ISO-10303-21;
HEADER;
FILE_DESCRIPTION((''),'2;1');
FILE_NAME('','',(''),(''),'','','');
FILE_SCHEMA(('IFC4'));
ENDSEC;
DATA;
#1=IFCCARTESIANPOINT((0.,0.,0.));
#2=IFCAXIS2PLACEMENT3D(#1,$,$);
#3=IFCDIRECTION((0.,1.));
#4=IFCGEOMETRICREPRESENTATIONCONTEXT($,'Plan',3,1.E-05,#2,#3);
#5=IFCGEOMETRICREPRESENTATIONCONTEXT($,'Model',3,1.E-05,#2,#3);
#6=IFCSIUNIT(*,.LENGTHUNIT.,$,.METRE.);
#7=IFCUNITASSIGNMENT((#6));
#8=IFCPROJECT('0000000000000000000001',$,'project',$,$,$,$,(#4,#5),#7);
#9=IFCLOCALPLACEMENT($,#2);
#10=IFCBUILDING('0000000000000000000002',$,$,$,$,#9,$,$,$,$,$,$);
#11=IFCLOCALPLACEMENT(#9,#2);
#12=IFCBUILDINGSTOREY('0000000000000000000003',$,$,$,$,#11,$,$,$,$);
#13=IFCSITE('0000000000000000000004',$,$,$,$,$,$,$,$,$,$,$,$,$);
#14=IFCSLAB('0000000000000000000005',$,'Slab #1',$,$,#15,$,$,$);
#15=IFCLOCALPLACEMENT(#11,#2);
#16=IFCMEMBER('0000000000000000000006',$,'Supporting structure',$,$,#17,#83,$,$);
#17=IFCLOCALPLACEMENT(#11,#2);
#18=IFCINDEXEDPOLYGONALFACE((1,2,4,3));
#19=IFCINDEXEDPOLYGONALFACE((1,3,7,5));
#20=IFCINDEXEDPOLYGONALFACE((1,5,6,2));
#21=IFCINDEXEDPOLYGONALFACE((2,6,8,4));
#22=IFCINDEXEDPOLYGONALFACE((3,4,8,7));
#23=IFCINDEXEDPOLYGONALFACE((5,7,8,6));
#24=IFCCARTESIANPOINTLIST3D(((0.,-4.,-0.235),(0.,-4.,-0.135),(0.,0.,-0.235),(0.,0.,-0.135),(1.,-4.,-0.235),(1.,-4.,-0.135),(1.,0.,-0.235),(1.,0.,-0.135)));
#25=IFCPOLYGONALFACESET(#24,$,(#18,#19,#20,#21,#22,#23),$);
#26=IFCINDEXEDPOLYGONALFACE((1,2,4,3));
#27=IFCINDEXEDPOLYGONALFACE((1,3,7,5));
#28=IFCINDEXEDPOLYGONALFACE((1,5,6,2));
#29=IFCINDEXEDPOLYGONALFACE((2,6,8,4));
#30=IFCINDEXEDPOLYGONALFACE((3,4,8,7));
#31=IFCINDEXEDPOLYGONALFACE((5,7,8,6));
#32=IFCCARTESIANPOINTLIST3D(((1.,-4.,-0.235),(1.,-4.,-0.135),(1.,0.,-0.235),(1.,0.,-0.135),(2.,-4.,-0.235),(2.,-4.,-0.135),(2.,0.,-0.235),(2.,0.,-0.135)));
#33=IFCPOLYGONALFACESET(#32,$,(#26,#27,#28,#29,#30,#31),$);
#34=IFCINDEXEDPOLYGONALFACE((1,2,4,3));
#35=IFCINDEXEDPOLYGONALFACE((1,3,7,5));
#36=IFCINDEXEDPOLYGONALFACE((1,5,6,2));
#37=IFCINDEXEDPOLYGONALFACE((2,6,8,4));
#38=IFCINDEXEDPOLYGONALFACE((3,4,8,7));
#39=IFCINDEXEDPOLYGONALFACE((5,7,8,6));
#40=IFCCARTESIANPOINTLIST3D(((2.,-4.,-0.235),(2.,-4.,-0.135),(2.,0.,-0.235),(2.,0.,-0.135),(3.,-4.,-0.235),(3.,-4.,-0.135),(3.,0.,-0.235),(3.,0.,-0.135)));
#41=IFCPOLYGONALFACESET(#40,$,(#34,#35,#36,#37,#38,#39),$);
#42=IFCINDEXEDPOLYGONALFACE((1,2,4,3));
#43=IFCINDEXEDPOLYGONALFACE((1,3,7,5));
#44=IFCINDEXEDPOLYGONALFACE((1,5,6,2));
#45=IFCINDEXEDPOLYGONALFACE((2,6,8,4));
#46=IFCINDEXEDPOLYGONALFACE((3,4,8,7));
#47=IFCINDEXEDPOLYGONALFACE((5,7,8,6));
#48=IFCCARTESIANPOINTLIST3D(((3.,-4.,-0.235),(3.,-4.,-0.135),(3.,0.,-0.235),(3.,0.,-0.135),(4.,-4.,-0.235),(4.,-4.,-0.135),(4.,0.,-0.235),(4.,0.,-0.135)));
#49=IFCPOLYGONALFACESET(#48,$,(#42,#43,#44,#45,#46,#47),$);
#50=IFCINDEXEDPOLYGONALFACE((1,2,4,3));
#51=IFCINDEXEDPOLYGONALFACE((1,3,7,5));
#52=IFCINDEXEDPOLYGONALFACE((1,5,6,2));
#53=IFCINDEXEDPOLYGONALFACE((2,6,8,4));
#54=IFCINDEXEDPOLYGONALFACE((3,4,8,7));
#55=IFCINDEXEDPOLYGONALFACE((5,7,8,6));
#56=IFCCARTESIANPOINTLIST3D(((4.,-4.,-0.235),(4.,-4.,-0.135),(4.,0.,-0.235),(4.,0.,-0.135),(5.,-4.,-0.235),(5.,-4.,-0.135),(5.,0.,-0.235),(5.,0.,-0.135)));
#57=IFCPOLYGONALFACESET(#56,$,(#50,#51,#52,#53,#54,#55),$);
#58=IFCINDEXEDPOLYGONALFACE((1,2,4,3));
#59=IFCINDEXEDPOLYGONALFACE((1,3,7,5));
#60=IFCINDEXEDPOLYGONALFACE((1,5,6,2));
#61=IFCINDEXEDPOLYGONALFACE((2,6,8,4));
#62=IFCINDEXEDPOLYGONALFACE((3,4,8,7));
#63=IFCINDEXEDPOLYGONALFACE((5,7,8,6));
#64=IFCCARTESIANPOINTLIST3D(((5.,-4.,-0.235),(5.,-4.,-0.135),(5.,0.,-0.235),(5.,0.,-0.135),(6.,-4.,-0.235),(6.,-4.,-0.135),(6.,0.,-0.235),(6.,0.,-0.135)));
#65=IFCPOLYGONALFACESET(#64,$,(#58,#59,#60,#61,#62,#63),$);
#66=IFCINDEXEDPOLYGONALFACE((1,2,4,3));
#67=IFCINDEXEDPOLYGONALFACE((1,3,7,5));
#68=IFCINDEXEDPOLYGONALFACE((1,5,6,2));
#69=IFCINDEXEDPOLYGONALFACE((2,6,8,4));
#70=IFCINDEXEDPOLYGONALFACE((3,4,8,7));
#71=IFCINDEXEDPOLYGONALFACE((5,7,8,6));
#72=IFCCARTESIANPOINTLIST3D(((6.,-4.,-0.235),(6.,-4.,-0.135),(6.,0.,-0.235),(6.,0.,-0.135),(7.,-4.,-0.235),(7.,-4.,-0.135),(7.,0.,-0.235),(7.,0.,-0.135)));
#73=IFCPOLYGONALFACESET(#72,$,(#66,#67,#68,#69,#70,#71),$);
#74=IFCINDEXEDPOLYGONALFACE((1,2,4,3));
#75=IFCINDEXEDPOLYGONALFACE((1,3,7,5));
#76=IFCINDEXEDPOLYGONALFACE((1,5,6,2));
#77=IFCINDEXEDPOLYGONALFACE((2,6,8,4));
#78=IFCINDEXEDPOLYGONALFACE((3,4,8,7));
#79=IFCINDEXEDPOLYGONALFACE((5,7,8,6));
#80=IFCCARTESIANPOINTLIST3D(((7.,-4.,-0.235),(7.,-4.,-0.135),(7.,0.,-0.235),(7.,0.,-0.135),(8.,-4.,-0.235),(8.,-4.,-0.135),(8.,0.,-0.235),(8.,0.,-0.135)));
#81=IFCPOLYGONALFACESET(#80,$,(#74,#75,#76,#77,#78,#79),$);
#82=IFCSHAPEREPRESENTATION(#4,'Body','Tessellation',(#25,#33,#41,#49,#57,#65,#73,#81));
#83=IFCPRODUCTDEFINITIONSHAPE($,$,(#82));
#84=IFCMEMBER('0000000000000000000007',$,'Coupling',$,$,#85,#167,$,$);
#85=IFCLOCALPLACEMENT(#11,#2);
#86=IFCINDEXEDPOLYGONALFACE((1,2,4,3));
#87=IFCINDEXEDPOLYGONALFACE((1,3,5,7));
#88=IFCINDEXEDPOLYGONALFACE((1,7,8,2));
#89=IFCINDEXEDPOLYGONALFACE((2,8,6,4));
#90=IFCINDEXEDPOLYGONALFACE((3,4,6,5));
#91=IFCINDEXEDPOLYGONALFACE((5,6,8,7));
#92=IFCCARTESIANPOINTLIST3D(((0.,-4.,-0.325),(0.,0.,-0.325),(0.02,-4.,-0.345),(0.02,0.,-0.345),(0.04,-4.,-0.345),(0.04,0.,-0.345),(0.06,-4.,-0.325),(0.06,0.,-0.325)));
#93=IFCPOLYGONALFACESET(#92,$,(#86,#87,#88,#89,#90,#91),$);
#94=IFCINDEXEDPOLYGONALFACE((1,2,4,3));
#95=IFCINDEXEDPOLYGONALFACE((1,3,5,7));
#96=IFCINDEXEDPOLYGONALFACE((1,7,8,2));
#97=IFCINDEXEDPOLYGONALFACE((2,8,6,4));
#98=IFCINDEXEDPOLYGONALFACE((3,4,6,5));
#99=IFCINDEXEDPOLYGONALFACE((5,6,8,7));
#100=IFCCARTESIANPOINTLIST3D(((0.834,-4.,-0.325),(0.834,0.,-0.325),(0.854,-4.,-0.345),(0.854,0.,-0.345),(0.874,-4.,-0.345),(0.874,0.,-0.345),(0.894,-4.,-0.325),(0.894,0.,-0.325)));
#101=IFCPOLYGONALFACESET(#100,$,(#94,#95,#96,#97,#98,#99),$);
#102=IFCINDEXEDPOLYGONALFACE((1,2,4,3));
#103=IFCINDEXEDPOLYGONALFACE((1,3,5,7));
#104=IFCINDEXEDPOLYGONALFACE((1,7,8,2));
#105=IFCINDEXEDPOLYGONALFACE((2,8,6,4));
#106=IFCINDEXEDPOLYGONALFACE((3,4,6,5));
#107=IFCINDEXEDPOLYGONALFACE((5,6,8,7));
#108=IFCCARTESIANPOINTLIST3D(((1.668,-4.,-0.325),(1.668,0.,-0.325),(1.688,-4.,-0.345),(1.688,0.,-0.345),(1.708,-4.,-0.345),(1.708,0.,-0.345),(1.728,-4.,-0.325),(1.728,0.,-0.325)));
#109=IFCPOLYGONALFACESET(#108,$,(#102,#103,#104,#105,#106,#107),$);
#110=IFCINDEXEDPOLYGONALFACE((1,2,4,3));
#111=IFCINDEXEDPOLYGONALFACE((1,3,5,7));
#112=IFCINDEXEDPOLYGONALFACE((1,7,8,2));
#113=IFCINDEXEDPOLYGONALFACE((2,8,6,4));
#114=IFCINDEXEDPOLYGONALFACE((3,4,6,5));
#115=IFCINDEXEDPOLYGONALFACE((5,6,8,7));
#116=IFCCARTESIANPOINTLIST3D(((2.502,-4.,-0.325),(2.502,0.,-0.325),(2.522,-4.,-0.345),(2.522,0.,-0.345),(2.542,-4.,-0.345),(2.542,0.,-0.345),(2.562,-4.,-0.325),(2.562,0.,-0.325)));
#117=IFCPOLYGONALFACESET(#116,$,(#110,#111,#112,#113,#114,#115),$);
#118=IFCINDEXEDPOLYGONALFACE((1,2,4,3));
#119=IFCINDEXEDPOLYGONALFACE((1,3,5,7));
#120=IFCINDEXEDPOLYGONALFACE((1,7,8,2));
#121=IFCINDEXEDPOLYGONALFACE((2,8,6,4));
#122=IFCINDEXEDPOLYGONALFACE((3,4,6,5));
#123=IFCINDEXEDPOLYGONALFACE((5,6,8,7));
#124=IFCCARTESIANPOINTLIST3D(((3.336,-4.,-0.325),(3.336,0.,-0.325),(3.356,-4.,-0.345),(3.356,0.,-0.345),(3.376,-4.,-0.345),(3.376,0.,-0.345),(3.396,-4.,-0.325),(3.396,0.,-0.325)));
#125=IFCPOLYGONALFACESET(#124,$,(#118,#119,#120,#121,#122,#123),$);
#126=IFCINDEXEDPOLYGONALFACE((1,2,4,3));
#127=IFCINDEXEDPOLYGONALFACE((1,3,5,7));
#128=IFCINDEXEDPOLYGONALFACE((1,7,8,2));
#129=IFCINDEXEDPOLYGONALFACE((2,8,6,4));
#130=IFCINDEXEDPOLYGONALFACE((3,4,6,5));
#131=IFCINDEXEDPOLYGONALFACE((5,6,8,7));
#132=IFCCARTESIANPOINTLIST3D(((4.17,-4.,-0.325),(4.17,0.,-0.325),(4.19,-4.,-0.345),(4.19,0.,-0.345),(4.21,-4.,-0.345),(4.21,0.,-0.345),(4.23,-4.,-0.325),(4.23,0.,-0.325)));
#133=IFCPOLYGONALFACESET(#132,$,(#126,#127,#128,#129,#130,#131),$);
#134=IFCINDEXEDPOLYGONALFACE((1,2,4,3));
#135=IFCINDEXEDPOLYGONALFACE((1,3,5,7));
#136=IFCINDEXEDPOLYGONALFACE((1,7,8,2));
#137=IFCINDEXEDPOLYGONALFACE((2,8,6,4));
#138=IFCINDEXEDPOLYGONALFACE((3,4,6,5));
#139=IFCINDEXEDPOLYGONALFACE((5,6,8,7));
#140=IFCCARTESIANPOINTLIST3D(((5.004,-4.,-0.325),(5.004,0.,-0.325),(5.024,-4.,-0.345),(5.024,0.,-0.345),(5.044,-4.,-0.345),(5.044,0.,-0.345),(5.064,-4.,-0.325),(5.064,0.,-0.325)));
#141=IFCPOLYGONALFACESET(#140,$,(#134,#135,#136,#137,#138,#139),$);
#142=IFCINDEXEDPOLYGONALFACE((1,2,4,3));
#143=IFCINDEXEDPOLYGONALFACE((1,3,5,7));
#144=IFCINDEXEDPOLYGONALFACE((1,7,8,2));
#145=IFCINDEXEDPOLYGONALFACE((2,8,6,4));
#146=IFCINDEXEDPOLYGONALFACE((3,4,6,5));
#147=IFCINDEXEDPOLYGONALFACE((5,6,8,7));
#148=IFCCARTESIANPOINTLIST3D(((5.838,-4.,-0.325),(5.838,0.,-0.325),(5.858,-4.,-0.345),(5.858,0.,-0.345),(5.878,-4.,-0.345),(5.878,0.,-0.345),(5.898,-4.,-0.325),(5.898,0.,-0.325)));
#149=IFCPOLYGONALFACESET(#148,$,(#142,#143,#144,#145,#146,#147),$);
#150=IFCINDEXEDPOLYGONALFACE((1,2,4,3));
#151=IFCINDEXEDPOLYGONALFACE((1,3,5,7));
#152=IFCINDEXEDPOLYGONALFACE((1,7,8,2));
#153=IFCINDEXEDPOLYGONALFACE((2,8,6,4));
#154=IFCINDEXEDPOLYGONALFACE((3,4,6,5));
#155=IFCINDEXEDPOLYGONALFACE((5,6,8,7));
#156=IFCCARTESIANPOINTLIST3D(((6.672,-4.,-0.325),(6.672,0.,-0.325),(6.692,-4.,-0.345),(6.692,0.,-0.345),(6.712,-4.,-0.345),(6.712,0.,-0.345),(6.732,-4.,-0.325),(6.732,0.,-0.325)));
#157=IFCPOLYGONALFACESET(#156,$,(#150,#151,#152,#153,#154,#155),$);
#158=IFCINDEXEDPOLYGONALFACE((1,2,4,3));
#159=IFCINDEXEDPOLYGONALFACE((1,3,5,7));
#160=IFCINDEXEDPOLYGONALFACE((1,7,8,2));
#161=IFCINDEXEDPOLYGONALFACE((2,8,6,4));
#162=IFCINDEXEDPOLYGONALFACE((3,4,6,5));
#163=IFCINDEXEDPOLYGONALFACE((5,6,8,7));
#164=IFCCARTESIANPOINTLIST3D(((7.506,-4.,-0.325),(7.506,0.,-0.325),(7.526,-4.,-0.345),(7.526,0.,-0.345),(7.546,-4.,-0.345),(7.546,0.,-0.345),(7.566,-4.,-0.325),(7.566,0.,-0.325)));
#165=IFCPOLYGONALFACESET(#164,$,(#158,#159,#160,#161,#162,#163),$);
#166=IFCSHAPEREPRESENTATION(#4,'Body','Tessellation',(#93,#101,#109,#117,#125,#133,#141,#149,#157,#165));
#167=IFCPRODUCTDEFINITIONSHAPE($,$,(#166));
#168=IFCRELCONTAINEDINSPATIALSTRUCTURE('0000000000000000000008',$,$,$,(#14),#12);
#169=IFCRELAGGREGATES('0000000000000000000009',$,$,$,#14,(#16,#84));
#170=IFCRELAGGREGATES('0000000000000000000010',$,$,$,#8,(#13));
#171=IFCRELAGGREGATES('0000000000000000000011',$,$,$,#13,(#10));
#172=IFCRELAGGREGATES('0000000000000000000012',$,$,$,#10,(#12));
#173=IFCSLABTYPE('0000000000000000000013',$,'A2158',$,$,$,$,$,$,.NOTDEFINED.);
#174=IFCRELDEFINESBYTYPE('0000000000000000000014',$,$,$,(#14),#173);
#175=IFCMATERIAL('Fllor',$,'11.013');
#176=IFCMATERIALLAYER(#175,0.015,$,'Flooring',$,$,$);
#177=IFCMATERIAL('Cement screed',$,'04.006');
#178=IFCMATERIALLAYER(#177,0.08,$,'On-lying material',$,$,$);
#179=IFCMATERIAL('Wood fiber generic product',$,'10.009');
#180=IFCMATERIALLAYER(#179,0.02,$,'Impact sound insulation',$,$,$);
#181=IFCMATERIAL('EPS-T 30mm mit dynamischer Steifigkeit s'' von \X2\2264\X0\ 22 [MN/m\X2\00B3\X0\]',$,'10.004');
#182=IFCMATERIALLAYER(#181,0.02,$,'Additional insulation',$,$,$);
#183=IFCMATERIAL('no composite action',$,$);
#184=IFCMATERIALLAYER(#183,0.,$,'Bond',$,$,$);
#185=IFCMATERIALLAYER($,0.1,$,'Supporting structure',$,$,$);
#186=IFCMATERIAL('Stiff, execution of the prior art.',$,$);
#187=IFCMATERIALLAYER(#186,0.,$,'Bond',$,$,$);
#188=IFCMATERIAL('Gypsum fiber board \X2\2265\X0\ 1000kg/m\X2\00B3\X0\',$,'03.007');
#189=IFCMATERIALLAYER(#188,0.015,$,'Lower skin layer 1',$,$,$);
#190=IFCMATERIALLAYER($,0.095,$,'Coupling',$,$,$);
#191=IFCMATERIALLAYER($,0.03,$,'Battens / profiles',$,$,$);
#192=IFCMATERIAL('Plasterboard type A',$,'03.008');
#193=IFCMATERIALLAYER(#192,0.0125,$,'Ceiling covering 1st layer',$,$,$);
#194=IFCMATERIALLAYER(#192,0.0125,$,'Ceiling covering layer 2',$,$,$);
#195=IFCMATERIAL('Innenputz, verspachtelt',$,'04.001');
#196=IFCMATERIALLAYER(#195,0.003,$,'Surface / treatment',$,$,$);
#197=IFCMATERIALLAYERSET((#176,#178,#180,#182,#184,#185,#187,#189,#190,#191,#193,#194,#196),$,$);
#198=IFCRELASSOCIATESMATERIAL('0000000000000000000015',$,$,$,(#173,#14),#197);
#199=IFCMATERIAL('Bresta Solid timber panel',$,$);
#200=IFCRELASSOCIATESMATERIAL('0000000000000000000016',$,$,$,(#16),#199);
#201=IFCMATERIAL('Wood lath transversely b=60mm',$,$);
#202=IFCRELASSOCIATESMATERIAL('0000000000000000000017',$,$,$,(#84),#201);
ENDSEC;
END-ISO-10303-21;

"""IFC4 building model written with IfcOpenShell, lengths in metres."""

from ifc_helpers import new_model, si_unit, direction, frame, frame_2d, origin, place, context, project, spatial, polyline, rectangle, outline, extrude, material, layer, layer_set, type_object, element, aggregate, save


model = new_model("IFC4")

# Units and contexts
plan_context = context("Plan", 3, precision=1e-05, world=origin(), true_north=direction((0.0, 1.0)))
model_context = context("Model", 3, precision=1e-05, world=origin(), true_north=direction((0.0, 1.0)))
ifc_project = project(units=[si_unit("LENGTHUNIT", "METRE")], contexts=[plan_context, model_context])

# Site, building, storey
site = spatial("IfcSite", under=ifc_project)
building_placement = place(None, origin())
building = spatial("IfcBuilding", under=site, at=building_placement)
storey_placement = place(building_placement, origin())
storey = spatial("IfcBuildingStorey", under=building, at=storey_placement)

# Slab, members
ifc_material_1 = material(Name="Fllor", Category="11.013")
ifc_layer_1 = layer(ifc_material_1, 0.015, Name="Flooring")
ifc_material_2 = material(Name="Cement screed", Category="04.006")
ifc_layer_2 = layer(ifc_material_2, 0.08, Name="On-lying material")
ifc_material_3 = material(Name="Wood fiber generic product", Category="10.009")
ifc_layer_3 = layer(ifc_material_3, 0.02, Name="Impact sound insulation")
ifc_material_4 = material(Name="EPS-T 30mm mit dynamischer Steifigkeit s' von ≤ 22 [MN/m³]", Category="10.004")
ifc_layer_4 = layer(ifc_material_4, 0.02, Name="Additional insulation")
ifc_material_5 = material(Name="no composite action")
ifc_layer_5 = layer(ifc_material_5, 0.0, Name="Bond")
ifc_layer_6 = layer(None, 0.1, Name="Supporting structure")
ifc_material_6 = material(Name="Stiff, execution of the prior art.")
ifc_layer_7 = layer(ifc_material_6, 0.0, Name="Bond")
ifc_material_7 = material(Name="Gypsum fiber board ≥ 1000kg/m³", Category="03.007")
ifc_layer_8 = layer(ifc_material_7, 0.015, Name="Lower skin layer 1")
ifc_layer_9 = layer(None, 0.095, Name="Coupling")
ifc_layer_10 = layer(None, 0.03, Name="Battens / profiles")
ifc_material_8 = material(Name="Plasterboard type A", Category="03.008")
ifc_layer_11 = layer(ifc_material_8, 0.0125, Name="Ceiling covering 1st layer")
ifc_layer_12 = layer(ifc_material_8, 0.0125, Name="Ceiling covering layer 2")
ifc_material_9 = material(Name="Innenputz, verspachtelt", Category="04.001")
ifc_layer_13 = layer(ifc_material_9, 0.003, Name="Surface / treatment")
ifc_layer_set = layer_set([ifc_layer_1, ifc_layer_2, ifc_layer_3, ifc_layer_4, ifc_layer_5, ifc_layer_6, ifc_layer_7, ifc_layer_8, ifc_layer_9, ifc_layer_10, ifc_layer_11, ifc_layer_12, ifc_layer_13])
slab_type = type_object("IfcSlabType", Name="A2158", PredefinedType="NOTDEFINED", material=ifc_layer_set)
slab_placement = place(None, frame((0.0, 0.0, 0.0), z_axis=(0.0, 0.0, -1.0), x_axis=(1.0, 0.0, 0.0)))
slab = element("IfcSlab", 1, at=slab_placement, inside=storey, type_object=slab_type, material=ifc_layer_set, Name="Slab #1")
ifc_material_10 = material(Name="Bresta Solid timber panel")
member_1_placement = place(slab_placement, origin())
member_1 = element("IfcMember", 2, at=member_1_placement, material=ifc_material_10, Name="Supporting structure", context=plan_context, shape_type="SweptSolid", body=[
    extrude(rectangle(XDim=1.0, YDim=0.1, at=frame_2d((0.5, 0.05), x_axis=(1.0, 0.0))), frame((0.0, 4.0, 0.135), z_axis=(0.0, -1.0, 0.0), x_axis=(1.0, 0.0, 0.0)), (0.0, 0.0, 1.0), 4.0),
    extrude(rectangle(XDim=1.0, YDim=0.1, at=frame_2d((0.5, 0.05), x_axis=(1.0, 0.0))), frame((1.0, 4.0, 0.135), z_axis=(0.0, -1.0, 0.0), x_axis=(1.0, 0.0, 0.0)), (0.0, 0.0, 1.0), 4.0),
    extrude(rectangle(XDim=1.0, YDim=0.1, at=frame_2d((0.5, 0.05), x_axis=(1.0, 0.0))), frame((2.0, 4.0, 0.135), z_axis=(0.0, -1.0, 0.0), x_axis=(1.0, 0.0, 0.0)), (0.0, 0.0, 1.0), 4.0),
    extrude(rectangle(XDim=1.0, YDim=0.1, at=frame_2d((0.5, 0.05), x_axis=(1.0, 0.0))), frame((3.0, 4.0, 0.135), z_axis=(0.0, -1.0, 0.0), x_axis=(1.0, 0.0, 0.0)), (0.0, 0.0, 1.0), 4.0),
    extrude(rectangle(XDim=1.0, YDim=0.1, at=frame_2d((0.5, 0.05), x_axis=(1.0, 0.0))), frame((4.0, 4.0, 0.135), z_axis=(0.0, -1.0, 0.0), x_axis=(1.0, 0.0, 0.0)), (0.0, 0.0, 1.0), 4.0),
    extrude(rectangle(XDim=1.0, YDim=0.1, at=frame_2d((0.5, 0.05), x_axis=(1.0, 0.0))), frame((5.0, 4.0, 0.135), z_axis=(0.0, -1.0, 0.0), x_axis=(1.0, 0.0, 0.0)), (0.0, 0.0, 1.0), 4.0),
    extrude(rectangle(XDim=1.0, YDim=0.1, at=frame_2d((0.5, 0.05), x_axis=(1.0, 0.0))), frame((6.0, 4.0, 0.135), z_axis=(0.0, -1.0, 0.0), x_axis=(1.0, 0.0, 0.0)), (0.0, 0.0, 1.0), 4.0),
    extrude(rectangle(XDim=1.0, YDim=0.1, at=frame_2d((0.5, 0.05), x_axis=(1.0, 0.0))), frame((7.0, 4.0, 0.135), z_axis=(0.0, -1.0, 0.0), x_axis=(1.0, 0.0, 0.0)), (0.0, 0.0, 1.0), 4.0),
])
ifc_material_11 = material(Name="Wood lath transversely b=60mm")
member_2_placement = place(slab_placement, origin())
member_2 = element("IfcMember", 3, at=member_2_placement, material=ifc_material_11, Name="Coupling", context=plan_context, shape_type="SweptSolid", body=[
    extrude(outline(polyline([(0.0, 0.0), (0.06, 0.0), (0.04, 0.02), (0.02, 0.02), (0.0, 0.0)])), frame((0.0, 4.0, 0.325), z_axis=(0.0, -1.0, 0.0), x_axis=(1.0, 0.0, 0.0)), (0.0, 0.0, 1.0), 4.0),
    extrude(outline(polyline([(0.0, 0.0), (0.06, 0.0), (0.04, 0.02), (0.02, 0.02), (0.0, 0.0)])), frame((0.834, 4.0, 0.325), z_axis=(0.0, -1.0, 0.0), x_axis=(1.0, 0.0, 0.0)), (0.0, 0.0, 1.0), 4.0),
    extrude(outline(polyline([(0.0, 0.0), (0.06, 0.0), (0.04, 0.02), (0.02, 0.02), (0.0, 0.0)])), frame((1.668, 4.0, 0.325), z_axis=(0.0, -1.0, 0.0), x_axis=(1.0, 0.0, 0.0)), (0.0, 0.0, 1.0), 4.0),
    extrude(outline(polyline([(0.0, 0.0), (0.06, 0.0), (0.04, 0.02), (0.02, 0.02), (0.0, 0.0)])), frame((2.502, 4.0, 0.325), z_axis=(0.0, -1.0, 0.0), x_axis=(1.0, 0.0, 0.0)), (0.0, 0.0, 1.0), 4.0),
    extrude(outline(polyline([(0.0, 0.0), (0.06, 0.0), (0.04, 0.02), (0.02, 0.02), (0.0, 0.0)])), frame((3.336, 4.0, 0.325), z_axis=(0.0, -1.0, 0.0), x_axis=(1.0, 0.0, 0.0)), (0.0, 0.0, 1.0), 4.0),
    extrude(outline(polyline([(0.0, 0.0), (0.06, 0.0), (0.04, 0.02), (0.02, 0.02), (0.0, 0.0)])), frame((4.17, 4.0, 0.325), z_axis=(0.0, -1.0, 0.0), x_axis=(1.0, 0.0, 0.0)), (0.0, 0.0, 1.0), 4.0),
    extrude(outline(polyline([(0.0, 0.0), (0.06, 0.0), (0.04, 0.02), (0.02, 0.02), (0.0, 0.0)])), frame((5.004, 4.0, 0.325), z_axis=(0.0, -1.0, 0.0), x_axis=(1.0, 0.0, 0.0)), (0.0, 0.0, 1.0), 4.0),
    extrude(outline(polyline([(0.0, 0.0), (0.06, 0.0), (0.04, 0.02), (0.02, 0.02), (0.0, 0.0)])), frame((5.838, 4.0, 0.325), z_axis=(0.0, -1.0, 0.0), x_axis=(1.0, 0.0, 0.0)), (0.0, 0.0, 1.0), 4.0),
    extrude(outline(polyline([(0.0, 0.0), (0.06, 0.0), (0.04, 0.02), (0.02, 0.02), (0.0, 0.0)])), frame((6.672, 4.0, 0.325), z_axis=(0.0, -1.0, 0.0), x_axis=(1.0, 0.0, 0.0)), (0.0, 0.0, 1.0), 4.0),
    extrude(outline(polyline([(0.0, 0.0), (0.06, 0.0), (0.04, 0.02), (0.02, 0.02), (0.0, 0.0)])), frame((7.506, 4.0, 0.325), z_axis=(0.0, -1.0, 0.0), x_axis=(1.0, 0.0, 0.0)), (0.0, 0.0, 1.0), 4.0),
])
aggregate(slab, [member_1, member_2])

save(model, "model.ifc")
